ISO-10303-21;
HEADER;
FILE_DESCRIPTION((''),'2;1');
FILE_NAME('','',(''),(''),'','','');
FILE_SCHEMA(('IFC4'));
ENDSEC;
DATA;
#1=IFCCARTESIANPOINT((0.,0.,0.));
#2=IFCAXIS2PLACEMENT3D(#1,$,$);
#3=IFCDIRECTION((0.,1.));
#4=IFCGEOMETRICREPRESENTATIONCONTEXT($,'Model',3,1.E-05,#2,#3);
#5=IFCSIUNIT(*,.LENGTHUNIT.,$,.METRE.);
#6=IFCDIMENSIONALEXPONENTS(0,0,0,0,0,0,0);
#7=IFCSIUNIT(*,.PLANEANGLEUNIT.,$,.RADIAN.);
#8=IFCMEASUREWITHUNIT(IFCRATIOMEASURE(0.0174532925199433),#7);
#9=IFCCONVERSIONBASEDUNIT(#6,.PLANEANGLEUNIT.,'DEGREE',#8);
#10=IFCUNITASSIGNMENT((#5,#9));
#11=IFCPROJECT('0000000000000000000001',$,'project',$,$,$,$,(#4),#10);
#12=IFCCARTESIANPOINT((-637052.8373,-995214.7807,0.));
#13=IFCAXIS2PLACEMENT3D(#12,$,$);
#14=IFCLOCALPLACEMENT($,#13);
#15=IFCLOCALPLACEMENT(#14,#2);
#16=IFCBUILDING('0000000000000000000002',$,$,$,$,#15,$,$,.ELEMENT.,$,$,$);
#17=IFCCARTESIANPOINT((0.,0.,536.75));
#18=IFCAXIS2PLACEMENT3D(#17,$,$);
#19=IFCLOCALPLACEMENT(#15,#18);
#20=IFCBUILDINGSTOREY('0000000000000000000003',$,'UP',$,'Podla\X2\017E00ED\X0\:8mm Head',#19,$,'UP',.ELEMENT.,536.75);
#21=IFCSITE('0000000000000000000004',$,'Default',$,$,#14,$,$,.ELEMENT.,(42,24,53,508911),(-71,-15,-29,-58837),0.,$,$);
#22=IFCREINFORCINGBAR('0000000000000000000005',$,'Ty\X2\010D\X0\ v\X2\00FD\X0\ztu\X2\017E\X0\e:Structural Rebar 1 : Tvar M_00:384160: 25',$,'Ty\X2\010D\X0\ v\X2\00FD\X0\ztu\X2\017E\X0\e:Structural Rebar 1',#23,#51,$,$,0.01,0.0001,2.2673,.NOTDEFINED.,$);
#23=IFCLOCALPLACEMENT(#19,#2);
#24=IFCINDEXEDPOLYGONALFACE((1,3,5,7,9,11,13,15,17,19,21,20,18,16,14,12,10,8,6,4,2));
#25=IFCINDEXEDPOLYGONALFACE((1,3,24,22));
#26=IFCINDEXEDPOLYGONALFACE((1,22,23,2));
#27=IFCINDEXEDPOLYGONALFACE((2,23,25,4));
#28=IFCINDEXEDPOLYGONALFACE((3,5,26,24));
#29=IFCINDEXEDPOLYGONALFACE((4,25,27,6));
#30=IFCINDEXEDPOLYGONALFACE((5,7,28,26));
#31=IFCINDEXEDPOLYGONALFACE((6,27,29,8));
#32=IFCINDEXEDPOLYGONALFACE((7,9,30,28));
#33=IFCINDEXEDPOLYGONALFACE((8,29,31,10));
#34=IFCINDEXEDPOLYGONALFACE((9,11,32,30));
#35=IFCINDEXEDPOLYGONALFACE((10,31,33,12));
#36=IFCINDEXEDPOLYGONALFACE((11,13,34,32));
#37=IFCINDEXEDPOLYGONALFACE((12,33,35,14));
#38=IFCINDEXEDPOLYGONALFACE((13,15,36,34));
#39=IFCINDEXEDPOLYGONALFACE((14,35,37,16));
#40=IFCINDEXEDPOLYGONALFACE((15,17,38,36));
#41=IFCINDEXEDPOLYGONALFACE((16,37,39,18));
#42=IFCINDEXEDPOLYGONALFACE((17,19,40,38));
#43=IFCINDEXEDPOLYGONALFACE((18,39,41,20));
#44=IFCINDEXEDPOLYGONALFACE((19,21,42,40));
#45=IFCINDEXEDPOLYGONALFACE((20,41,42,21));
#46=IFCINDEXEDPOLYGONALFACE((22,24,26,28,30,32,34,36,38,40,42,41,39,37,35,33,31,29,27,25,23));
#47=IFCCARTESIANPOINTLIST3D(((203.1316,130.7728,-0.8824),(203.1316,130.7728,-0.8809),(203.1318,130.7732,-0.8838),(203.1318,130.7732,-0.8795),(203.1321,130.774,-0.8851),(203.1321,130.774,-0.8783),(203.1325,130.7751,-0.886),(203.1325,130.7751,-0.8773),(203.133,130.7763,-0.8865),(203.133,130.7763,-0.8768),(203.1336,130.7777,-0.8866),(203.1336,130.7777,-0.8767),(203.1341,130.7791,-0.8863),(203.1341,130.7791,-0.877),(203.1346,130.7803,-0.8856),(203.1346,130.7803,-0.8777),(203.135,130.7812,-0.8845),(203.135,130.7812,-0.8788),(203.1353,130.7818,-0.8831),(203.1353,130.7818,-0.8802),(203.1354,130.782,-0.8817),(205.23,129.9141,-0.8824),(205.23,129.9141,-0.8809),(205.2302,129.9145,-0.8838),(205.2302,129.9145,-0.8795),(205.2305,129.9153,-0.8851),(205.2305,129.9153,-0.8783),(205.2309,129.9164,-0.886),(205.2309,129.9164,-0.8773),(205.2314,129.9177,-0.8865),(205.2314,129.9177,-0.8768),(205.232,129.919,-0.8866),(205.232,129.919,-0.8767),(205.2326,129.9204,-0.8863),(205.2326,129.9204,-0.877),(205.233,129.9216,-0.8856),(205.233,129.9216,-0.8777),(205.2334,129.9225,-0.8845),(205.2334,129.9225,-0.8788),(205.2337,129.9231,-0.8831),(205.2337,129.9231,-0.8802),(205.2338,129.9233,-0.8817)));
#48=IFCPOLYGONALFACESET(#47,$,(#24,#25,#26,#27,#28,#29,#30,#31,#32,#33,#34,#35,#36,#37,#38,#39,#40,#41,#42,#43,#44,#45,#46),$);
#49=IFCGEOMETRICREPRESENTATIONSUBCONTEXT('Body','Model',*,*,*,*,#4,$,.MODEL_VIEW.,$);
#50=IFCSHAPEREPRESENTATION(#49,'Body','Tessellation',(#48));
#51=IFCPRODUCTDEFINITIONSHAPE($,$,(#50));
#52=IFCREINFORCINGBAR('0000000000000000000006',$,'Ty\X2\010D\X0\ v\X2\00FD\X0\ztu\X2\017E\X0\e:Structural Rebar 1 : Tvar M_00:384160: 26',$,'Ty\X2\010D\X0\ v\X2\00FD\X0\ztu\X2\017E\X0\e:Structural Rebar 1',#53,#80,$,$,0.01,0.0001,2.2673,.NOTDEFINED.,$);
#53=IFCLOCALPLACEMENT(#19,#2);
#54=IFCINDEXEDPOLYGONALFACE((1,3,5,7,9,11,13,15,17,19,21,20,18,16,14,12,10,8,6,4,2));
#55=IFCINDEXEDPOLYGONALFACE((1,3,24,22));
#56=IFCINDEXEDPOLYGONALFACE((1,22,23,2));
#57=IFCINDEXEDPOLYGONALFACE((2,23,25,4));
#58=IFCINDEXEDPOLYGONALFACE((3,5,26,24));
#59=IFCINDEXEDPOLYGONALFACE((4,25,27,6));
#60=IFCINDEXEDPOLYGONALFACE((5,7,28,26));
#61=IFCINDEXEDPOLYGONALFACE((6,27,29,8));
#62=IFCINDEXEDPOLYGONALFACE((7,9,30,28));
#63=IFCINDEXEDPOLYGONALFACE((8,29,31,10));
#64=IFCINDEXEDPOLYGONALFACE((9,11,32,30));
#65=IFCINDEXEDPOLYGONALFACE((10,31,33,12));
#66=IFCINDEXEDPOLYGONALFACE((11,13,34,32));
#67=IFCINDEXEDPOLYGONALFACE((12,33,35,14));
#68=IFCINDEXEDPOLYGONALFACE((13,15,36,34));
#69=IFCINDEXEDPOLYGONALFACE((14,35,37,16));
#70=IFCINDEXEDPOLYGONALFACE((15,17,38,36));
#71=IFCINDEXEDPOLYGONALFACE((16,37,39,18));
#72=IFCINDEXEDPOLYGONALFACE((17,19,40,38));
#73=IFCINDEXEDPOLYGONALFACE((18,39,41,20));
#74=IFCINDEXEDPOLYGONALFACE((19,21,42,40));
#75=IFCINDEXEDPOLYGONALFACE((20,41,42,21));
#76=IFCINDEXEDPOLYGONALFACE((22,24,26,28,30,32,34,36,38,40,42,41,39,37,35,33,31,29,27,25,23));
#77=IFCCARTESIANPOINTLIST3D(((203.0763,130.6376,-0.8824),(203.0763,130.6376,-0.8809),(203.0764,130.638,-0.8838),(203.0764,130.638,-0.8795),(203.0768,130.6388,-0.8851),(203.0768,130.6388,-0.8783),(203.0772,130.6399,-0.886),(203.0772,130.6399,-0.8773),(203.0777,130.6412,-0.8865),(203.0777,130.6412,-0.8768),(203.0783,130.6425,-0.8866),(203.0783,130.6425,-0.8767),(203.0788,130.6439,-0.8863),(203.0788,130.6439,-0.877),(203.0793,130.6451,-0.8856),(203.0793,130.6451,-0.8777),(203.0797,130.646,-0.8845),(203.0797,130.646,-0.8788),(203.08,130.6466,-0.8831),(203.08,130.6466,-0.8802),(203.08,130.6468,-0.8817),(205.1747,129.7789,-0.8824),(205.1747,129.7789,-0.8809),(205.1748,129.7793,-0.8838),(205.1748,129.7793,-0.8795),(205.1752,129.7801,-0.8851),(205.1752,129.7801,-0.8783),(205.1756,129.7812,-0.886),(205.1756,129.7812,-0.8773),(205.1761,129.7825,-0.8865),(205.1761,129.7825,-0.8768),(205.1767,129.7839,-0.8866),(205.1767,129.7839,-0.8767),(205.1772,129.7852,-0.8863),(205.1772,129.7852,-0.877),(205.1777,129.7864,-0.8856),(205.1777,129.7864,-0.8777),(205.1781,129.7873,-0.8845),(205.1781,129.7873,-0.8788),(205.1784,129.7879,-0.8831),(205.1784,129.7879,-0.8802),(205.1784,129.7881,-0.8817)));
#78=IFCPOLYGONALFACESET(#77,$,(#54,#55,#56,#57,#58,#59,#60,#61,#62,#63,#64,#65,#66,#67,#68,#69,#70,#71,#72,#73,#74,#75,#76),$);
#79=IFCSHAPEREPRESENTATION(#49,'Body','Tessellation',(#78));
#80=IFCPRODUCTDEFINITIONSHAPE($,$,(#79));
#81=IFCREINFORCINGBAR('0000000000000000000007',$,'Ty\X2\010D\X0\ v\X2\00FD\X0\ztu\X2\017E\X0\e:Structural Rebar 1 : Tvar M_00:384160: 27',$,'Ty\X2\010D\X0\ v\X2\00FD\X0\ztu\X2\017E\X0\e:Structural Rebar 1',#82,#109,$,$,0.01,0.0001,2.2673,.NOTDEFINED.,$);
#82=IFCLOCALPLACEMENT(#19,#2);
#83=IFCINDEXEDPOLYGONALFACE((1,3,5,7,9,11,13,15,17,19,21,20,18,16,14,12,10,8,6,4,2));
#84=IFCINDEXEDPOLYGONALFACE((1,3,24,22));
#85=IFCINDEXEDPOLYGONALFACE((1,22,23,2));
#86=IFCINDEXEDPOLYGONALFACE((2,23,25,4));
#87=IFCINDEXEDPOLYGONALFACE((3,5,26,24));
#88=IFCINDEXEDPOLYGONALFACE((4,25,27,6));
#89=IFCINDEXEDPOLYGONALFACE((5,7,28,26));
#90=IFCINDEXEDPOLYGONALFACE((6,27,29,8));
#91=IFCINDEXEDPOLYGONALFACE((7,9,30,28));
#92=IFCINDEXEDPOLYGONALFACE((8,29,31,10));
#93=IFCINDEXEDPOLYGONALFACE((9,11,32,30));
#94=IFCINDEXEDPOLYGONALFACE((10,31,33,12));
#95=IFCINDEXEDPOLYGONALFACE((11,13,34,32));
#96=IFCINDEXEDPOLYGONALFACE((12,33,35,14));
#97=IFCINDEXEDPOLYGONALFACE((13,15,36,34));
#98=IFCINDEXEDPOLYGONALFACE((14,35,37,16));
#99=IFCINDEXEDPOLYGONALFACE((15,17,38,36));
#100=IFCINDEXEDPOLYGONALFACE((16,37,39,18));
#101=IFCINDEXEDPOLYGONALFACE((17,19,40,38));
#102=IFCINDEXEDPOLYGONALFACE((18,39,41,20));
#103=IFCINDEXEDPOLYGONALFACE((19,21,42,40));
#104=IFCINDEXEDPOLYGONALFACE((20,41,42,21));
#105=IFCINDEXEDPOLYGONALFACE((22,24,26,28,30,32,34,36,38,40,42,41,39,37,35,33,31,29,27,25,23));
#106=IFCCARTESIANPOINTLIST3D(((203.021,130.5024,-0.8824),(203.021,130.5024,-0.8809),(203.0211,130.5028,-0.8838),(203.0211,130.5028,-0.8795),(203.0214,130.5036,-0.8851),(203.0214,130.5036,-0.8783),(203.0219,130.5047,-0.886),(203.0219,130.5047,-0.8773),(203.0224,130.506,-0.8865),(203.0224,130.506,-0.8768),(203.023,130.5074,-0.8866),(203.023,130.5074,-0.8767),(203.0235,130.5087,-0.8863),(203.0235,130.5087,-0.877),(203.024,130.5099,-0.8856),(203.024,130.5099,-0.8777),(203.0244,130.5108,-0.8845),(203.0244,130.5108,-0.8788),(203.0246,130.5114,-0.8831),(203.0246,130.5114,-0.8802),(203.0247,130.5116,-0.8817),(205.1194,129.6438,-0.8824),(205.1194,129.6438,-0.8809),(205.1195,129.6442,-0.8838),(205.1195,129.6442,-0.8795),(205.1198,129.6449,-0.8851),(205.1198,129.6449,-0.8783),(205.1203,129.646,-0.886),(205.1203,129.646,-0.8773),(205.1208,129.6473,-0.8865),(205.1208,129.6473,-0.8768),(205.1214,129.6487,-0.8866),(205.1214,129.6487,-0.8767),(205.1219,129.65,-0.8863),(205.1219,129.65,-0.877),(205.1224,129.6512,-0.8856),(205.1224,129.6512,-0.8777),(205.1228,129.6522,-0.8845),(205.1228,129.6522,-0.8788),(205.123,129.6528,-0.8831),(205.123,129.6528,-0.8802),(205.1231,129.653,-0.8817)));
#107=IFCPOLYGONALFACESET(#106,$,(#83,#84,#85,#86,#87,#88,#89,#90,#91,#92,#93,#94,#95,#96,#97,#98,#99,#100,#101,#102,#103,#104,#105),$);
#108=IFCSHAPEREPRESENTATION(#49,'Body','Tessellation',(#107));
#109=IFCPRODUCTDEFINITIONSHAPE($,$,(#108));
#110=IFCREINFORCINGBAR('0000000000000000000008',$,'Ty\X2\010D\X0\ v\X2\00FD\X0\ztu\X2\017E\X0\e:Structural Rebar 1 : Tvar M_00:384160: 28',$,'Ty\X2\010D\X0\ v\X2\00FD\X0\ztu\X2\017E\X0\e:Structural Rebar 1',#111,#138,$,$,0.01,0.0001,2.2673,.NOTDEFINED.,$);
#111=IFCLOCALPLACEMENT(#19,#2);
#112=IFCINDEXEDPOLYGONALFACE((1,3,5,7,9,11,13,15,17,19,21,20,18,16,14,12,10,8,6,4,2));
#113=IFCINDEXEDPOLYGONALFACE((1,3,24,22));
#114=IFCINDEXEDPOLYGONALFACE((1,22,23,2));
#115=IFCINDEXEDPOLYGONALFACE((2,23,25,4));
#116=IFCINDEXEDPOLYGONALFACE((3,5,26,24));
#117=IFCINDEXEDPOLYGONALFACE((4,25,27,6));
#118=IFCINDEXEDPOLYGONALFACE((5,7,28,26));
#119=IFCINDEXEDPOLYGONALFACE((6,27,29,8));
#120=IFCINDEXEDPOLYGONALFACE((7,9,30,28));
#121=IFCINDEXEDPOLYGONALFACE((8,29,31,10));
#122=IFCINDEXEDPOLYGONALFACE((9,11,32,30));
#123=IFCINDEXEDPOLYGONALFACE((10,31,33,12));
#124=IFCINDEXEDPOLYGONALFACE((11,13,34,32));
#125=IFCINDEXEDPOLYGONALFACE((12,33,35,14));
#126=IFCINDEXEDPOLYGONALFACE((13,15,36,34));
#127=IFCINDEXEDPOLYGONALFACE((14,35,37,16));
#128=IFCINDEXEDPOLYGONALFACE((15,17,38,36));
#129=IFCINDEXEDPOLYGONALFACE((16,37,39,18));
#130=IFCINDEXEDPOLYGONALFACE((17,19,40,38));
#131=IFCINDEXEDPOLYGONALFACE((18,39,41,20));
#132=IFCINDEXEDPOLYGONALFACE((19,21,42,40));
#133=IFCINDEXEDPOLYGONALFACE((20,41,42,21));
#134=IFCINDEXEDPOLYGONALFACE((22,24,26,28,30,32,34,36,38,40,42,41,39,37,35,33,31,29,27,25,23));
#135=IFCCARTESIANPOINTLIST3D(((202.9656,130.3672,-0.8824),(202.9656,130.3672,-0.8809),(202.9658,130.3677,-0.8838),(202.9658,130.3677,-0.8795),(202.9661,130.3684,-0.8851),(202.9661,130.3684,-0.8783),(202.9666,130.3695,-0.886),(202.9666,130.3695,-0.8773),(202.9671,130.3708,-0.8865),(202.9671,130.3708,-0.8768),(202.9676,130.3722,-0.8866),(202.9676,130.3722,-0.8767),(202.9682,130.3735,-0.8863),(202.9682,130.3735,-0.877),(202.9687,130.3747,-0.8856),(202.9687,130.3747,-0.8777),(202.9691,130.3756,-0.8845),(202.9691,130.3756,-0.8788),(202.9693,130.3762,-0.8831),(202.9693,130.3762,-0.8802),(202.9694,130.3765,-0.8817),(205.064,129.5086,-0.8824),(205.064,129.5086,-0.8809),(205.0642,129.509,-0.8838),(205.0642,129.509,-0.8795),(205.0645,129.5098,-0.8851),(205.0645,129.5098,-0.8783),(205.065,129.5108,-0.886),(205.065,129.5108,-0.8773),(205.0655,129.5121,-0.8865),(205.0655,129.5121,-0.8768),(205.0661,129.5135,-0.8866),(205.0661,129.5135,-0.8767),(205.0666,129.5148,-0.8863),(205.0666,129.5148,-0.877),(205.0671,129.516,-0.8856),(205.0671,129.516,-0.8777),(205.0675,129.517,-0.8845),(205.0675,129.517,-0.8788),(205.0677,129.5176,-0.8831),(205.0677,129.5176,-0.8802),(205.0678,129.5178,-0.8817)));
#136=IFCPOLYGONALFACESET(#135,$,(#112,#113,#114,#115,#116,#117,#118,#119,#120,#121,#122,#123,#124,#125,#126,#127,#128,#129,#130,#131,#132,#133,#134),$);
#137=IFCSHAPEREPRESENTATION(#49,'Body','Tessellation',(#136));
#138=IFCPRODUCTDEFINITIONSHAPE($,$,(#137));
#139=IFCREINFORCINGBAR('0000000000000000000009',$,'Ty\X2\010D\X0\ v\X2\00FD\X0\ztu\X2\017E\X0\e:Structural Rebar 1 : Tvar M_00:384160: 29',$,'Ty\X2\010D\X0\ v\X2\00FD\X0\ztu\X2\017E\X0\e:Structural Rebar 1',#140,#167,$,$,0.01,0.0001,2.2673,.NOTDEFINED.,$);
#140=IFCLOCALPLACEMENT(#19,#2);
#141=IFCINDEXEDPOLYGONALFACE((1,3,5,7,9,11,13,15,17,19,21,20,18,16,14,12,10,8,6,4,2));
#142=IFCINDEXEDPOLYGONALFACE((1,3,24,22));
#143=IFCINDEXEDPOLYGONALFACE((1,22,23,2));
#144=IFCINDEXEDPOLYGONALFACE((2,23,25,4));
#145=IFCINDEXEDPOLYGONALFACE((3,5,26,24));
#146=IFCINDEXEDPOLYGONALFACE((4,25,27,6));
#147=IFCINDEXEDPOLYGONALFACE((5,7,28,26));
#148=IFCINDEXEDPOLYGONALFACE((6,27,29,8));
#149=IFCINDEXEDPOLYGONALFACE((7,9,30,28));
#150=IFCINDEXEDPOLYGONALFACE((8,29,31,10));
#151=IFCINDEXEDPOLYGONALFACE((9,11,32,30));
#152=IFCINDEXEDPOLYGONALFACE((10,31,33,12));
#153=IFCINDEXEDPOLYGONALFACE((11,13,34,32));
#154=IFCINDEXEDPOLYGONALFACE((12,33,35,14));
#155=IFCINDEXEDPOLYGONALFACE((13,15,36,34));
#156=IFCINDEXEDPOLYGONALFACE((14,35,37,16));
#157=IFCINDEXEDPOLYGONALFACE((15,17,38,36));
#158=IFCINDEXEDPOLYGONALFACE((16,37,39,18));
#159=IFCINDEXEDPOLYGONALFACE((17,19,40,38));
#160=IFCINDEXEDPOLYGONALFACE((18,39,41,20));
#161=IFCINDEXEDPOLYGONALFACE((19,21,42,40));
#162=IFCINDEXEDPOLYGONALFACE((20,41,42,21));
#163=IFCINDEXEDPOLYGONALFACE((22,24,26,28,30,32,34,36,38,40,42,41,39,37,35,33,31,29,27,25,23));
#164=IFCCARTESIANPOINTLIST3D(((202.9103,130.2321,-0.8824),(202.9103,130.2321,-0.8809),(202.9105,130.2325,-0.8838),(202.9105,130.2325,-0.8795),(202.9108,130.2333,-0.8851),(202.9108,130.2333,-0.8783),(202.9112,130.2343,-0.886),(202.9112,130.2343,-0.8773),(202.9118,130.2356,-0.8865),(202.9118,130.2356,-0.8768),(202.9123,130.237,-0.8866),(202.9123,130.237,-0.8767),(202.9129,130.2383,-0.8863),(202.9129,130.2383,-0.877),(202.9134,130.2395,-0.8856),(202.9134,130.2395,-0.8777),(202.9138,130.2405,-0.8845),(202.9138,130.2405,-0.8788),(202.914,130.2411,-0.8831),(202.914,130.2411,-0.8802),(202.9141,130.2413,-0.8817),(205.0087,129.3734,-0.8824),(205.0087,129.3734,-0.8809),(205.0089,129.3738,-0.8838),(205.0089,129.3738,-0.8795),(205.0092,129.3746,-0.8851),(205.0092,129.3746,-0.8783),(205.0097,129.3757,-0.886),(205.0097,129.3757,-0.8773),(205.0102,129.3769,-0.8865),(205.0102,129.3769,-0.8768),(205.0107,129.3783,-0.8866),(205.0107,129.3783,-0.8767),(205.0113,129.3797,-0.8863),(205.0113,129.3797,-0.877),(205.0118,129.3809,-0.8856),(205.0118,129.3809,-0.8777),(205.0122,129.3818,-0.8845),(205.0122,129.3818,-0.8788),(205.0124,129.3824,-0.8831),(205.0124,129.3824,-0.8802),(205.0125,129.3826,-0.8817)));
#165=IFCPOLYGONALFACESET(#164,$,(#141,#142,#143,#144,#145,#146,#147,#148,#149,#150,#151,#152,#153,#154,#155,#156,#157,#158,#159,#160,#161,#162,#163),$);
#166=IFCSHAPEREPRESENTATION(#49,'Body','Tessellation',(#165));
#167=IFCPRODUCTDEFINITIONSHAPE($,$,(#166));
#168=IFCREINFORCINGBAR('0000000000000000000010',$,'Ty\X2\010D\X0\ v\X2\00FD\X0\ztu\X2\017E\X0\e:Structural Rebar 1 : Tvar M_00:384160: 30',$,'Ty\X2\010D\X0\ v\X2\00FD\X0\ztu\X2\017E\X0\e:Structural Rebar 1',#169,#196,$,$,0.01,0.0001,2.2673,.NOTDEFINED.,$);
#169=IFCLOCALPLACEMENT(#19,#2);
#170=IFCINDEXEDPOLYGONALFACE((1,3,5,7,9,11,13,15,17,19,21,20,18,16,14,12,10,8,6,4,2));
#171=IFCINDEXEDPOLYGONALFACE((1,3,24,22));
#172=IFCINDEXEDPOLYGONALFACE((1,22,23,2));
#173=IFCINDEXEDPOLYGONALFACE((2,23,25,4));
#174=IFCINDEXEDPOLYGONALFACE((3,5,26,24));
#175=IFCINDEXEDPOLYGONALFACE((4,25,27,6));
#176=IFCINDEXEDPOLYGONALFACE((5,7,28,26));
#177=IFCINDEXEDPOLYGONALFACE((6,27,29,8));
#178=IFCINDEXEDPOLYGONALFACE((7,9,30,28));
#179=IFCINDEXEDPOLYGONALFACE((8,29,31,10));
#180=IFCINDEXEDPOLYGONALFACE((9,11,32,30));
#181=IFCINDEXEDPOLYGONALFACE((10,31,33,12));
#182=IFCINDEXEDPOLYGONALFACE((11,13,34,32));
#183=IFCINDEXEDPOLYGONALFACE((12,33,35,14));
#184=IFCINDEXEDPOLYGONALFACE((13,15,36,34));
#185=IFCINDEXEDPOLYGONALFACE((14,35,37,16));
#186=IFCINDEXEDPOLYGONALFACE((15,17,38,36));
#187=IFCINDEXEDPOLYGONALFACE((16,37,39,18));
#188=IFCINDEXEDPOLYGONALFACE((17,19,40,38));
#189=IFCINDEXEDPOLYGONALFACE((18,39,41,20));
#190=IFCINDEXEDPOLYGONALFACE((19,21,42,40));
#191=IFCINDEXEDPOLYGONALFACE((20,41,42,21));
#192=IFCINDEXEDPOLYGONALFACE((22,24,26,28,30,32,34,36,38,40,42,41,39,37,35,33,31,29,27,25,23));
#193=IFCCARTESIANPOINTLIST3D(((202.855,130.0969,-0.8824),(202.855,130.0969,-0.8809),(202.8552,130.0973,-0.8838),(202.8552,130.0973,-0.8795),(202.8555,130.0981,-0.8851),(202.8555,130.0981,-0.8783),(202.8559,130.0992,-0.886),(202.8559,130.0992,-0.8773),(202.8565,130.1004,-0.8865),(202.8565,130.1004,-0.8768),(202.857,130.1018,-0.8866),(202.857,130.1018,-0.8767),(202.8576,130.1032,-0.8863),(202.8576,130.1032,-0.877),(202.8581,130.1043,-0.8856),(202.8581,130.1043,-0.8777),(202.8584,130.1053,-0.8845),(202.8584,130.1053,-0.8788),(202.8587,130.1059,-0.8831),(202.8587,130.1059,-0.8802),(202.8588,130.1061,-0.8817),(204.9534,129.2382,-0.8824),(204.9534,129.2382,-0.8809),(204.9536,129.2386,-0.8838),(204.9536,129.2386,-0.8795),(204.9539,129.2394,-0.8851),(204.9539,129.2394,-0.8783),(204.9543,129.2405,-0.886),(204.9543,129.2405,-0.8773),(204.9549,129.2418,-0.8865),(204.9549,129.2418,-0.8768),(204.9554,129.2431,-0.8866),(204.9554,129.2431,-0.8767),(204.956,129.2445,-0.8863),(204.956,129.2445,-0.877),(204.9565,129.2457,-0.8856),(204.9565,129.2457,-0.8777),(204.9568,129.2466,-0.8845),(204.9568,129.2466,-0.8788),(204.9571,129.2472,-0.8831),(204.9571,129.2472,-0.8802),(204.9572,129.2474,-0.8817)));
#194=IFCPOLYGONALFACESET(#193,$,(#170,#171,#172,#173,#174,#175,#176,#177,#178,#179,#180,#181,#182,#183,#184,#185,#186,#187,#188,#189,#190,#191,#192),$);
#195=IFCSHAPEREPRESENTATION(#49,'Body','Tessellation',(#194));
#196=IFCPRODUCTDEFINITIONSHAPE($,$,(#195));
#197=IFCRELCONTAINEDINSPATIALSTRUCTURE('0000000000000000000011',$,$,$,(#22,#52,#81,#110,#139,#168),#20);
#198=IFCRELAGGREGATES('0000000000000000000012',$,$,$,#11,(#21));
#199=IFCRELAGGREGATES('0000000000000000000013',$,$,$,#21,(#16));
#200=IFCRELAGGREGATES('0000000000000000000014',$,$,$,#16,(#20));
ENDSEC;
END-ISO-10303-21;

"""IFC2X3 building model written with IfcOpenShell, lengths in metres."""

from ifc_helpers import new_model, entity, si_unit, converted_unit, direction, frame, origin, place, context, subcontext, project, spatial, element, save


model = new_model("IFC2X3")

# Units and contexts
model_context = context("Model", 3, precision=1e-05, world=origin(), true_north=direction((0.0, 1.0)))
body_context = subcontext(model_context, "Body", "Model", "MODEL_VIEW")
ifc_project = project(units=[si_unit("LENGTHUNIT", "METRE"), converted_unit("PLANEANGLEUNIT", "DEGREE", entity("IfcRatioMeasure", 0.0174532925199433), si_unit("PLANEANGLEUNIT", "RADIAN"), dimensions=[0, 0, 0, 0, 0, 0, 0])], contexts=[model_context])

# Site, building, storey
site_placement = place(None, frame((-637052.8373, -995214.7807, 0.0)))
site = spatial("IfcSite", under=ifc_project, at=site_placement, Name="Default", CompositionType="ELEMENT", RefLatitude=(42, 24, 53, 508911), RefLongitude=(-71, -15, -29, -58837), RefElevation=0.0)
building_placement = place(site_placement, origin())
building = spatial("IfcBuilding", under=site, at=building_placement, CompositionType="ELEMENT")
storey_placement = place(building_placement, frame((0.0, 0.0, 536.75)))
storey = spatial("IfcBuildingStorey", under=building, at=storey_placement, Name="UP", ObjectType="Podlaží:8mm Head", LongName="UP", CompositionType="ELEMENT", Elevation=536.75)

# Reinforcing bars
reinforcing_bar_1_placement = place(storey_placement, origin())
element("IfcReinforcingBar", 1, at=reinforcing_bar_1_placement, inside=storey, Name="Tyč výztuže:Structural Rebar 1 : Tvar M_00:384160: 25", ObjectType="Tyč výztuže:Structural Rebar 1", BarLength=2.2673, BarRole="NOTDEFINED", CrossSectionArea=0.0001, NominalDiameter=0.01, context=body_context, shape_type="AdvancedSweptSolid", body=[
    entity("IfcSweptDiskSolid", entity("IfcCompositeCurve", [entity("IfcCompositeCurveSegment", "CONTINUOUS", True, entity("IfcPolyline", [entity("IfcCartesianPoint", [-205.2319, -129.9187, 0.8817]), entity("IfcCartesianPoint", [-203.1335, -130.7774, 0.8817])]))], False), 0.005, None, 0.0, 1.0),
])
reinforcing_bar_2_placement = place(storey_placement, origin())
element("IfcReinforcingBar", 2, at=reinforcing_bar_2_placement, inside=storey, Name="Tyč výztuže:Structural Rebar 1 : Tvar M_00:384160: 26", ObjectType="Tyč výztuže:Structural Rebar 1", BarLength=2.2673, BarRole="NOTDEFINED", CrossSectionArea=0.0001, NominalDiameter=0.01, context=body_context, shape_type="AdvancedSweptSolid", body=[
    entity("IfcSweptDiskSolid", entity("IfcCompositeCurve", [entity("IfcCompositeCurveSegment", "CONTINUOUS", True, entity("IfcPolyline", [entity("IfcCartesianPoint", [-205.1765, -129.7835, 0.8817]), entity("IfcCartesianPoint", [-203.0781, -130.6422, 0.8817])]))], False), 0.005, None, 0.0, 1.0),
])
reinforcing_bar_3_placement = place(storey_placement, origin())
element("IfcReinforcingBar", 3, at=reinforcing_bar_3_placement, inside=storey, Name="Tyč výztuže:Structural Rebar 1 : Tvar M_00:384160: 27", ObjectType="Tyč výztuže:Structural Rebar 1", BarLength=2.2673, BarRole="NOTDEFINED", CrossSectionArea=0.0001, NominalDiameter=0.01, context=body_context, shape_type="AdvancedSweptSolid", body=[
    entity("IfcSweptDiskSolid", entity("IfcCompositeCurve", [entity("IfcCompositeCurveSegment", "CONTINUOUS", True, entity("IfcPolyline", [entity("IfcCartesianPoint", [-205.1212, -129.6483, 0.8817]), entity("IfcCartesianPoint", [-203.0228, -130.507, 0.8817])]))], False), 0.005, None, 0.0, 1.0),
])
reinforcing_bar_4_placement = place(storey_placement, origin())
element("IfcReinforcingBar", 4, at=reinforcing_bar_4_placement, inside=storey, Name="Tyč výztuže:Structural Rebar 1 : Tvar M_00:384160: 28", ObjectType="Tyč výztuže:Structural Rebar 1", BarLength=2.2673, BarRole="NOTDEFINED", CrossSectionArea=0.0001, NominalDiameter=0.01, context=body_context, shape_type="AdvancedSweptSolid", body=[
    entity("IfcSweptDiskSolid", entity("IfcCompositeCurve", [entity("IfcCompositeCurveSegment", "CONTINUOUS", True, entity("IfcPolyline", [entity("IfcCartesianPoint", [-205.0659, -129.5131, 0.8817]), entity("IfcCartesianPoint", [-202.9675, -130.3718, 0.8817])]))], False), 0.005, None, 0.0, 1.0),
])
reinforcing_bar_5_placement = place(storey_placement, origin())
element("IfcReinforcingBar", 5, at=reinforcing_bar_5_placement, inside=storey, Name="Tyč výztuže:Structural Rebar 1 : Tvar M_00:384160: 29", ObjectType="Tyč výztuže:Structural Rebar 1", BarLength=2.2673, BarRole="NOTDEFINED", CrossSectionArea=0.0001, NominalDiameter=0.01, context=body_context, shape_type="AdvancedSweptSolid", body=[
    entity("IfcSweptDiskSolid", entity("IfcCompositeCurve", [entity("IfcCompositeCurveSegment", "CONTINUOUS", True, entity("IfcPolyline", [entity("IfcCartesianPoint", [-205.0106, -129.378, 0.8817]), entity("IfcCartesianPoint", [-202.9122, -130.2366, 0.8817])]))], False), 0.005, None, 0.0, 1.0),
])
reinforcing_bar_6_placement = place(storey_placement, origin())
element("IfcReinforcingBar", 6, at=reinforcing_bar_6_placement, inside=storey, Name="Tyč výztuže:Structural Rebar 1 : Tvar M_00:384160: 30", ObjectType="Tyč výztuže:Structural Rebar 1", BarLength=2.2673, BarRole="NOTDEFINED", CrossSectionArea=0.0001, NominalDiameter=0.01, context=body_context, shape_type="AdvancedSweptSolid", body=[
    entity("IfcSweptDiskSolid", entity("IfcCompositeCurve", [entity("IfcCompositeCurveSegment", "CONTINUOUS", True, entity("IfcPolyline", [entity("IfcCartesianPoint", [-204.9553, -129.2428, 0.8817]), entity("IfcCartesianPoint", [-202.8569, -130.1015, 0.8817])]))], False), 0.005, None, 0.0, 1.0),
])

save(model, "model.ifc")
